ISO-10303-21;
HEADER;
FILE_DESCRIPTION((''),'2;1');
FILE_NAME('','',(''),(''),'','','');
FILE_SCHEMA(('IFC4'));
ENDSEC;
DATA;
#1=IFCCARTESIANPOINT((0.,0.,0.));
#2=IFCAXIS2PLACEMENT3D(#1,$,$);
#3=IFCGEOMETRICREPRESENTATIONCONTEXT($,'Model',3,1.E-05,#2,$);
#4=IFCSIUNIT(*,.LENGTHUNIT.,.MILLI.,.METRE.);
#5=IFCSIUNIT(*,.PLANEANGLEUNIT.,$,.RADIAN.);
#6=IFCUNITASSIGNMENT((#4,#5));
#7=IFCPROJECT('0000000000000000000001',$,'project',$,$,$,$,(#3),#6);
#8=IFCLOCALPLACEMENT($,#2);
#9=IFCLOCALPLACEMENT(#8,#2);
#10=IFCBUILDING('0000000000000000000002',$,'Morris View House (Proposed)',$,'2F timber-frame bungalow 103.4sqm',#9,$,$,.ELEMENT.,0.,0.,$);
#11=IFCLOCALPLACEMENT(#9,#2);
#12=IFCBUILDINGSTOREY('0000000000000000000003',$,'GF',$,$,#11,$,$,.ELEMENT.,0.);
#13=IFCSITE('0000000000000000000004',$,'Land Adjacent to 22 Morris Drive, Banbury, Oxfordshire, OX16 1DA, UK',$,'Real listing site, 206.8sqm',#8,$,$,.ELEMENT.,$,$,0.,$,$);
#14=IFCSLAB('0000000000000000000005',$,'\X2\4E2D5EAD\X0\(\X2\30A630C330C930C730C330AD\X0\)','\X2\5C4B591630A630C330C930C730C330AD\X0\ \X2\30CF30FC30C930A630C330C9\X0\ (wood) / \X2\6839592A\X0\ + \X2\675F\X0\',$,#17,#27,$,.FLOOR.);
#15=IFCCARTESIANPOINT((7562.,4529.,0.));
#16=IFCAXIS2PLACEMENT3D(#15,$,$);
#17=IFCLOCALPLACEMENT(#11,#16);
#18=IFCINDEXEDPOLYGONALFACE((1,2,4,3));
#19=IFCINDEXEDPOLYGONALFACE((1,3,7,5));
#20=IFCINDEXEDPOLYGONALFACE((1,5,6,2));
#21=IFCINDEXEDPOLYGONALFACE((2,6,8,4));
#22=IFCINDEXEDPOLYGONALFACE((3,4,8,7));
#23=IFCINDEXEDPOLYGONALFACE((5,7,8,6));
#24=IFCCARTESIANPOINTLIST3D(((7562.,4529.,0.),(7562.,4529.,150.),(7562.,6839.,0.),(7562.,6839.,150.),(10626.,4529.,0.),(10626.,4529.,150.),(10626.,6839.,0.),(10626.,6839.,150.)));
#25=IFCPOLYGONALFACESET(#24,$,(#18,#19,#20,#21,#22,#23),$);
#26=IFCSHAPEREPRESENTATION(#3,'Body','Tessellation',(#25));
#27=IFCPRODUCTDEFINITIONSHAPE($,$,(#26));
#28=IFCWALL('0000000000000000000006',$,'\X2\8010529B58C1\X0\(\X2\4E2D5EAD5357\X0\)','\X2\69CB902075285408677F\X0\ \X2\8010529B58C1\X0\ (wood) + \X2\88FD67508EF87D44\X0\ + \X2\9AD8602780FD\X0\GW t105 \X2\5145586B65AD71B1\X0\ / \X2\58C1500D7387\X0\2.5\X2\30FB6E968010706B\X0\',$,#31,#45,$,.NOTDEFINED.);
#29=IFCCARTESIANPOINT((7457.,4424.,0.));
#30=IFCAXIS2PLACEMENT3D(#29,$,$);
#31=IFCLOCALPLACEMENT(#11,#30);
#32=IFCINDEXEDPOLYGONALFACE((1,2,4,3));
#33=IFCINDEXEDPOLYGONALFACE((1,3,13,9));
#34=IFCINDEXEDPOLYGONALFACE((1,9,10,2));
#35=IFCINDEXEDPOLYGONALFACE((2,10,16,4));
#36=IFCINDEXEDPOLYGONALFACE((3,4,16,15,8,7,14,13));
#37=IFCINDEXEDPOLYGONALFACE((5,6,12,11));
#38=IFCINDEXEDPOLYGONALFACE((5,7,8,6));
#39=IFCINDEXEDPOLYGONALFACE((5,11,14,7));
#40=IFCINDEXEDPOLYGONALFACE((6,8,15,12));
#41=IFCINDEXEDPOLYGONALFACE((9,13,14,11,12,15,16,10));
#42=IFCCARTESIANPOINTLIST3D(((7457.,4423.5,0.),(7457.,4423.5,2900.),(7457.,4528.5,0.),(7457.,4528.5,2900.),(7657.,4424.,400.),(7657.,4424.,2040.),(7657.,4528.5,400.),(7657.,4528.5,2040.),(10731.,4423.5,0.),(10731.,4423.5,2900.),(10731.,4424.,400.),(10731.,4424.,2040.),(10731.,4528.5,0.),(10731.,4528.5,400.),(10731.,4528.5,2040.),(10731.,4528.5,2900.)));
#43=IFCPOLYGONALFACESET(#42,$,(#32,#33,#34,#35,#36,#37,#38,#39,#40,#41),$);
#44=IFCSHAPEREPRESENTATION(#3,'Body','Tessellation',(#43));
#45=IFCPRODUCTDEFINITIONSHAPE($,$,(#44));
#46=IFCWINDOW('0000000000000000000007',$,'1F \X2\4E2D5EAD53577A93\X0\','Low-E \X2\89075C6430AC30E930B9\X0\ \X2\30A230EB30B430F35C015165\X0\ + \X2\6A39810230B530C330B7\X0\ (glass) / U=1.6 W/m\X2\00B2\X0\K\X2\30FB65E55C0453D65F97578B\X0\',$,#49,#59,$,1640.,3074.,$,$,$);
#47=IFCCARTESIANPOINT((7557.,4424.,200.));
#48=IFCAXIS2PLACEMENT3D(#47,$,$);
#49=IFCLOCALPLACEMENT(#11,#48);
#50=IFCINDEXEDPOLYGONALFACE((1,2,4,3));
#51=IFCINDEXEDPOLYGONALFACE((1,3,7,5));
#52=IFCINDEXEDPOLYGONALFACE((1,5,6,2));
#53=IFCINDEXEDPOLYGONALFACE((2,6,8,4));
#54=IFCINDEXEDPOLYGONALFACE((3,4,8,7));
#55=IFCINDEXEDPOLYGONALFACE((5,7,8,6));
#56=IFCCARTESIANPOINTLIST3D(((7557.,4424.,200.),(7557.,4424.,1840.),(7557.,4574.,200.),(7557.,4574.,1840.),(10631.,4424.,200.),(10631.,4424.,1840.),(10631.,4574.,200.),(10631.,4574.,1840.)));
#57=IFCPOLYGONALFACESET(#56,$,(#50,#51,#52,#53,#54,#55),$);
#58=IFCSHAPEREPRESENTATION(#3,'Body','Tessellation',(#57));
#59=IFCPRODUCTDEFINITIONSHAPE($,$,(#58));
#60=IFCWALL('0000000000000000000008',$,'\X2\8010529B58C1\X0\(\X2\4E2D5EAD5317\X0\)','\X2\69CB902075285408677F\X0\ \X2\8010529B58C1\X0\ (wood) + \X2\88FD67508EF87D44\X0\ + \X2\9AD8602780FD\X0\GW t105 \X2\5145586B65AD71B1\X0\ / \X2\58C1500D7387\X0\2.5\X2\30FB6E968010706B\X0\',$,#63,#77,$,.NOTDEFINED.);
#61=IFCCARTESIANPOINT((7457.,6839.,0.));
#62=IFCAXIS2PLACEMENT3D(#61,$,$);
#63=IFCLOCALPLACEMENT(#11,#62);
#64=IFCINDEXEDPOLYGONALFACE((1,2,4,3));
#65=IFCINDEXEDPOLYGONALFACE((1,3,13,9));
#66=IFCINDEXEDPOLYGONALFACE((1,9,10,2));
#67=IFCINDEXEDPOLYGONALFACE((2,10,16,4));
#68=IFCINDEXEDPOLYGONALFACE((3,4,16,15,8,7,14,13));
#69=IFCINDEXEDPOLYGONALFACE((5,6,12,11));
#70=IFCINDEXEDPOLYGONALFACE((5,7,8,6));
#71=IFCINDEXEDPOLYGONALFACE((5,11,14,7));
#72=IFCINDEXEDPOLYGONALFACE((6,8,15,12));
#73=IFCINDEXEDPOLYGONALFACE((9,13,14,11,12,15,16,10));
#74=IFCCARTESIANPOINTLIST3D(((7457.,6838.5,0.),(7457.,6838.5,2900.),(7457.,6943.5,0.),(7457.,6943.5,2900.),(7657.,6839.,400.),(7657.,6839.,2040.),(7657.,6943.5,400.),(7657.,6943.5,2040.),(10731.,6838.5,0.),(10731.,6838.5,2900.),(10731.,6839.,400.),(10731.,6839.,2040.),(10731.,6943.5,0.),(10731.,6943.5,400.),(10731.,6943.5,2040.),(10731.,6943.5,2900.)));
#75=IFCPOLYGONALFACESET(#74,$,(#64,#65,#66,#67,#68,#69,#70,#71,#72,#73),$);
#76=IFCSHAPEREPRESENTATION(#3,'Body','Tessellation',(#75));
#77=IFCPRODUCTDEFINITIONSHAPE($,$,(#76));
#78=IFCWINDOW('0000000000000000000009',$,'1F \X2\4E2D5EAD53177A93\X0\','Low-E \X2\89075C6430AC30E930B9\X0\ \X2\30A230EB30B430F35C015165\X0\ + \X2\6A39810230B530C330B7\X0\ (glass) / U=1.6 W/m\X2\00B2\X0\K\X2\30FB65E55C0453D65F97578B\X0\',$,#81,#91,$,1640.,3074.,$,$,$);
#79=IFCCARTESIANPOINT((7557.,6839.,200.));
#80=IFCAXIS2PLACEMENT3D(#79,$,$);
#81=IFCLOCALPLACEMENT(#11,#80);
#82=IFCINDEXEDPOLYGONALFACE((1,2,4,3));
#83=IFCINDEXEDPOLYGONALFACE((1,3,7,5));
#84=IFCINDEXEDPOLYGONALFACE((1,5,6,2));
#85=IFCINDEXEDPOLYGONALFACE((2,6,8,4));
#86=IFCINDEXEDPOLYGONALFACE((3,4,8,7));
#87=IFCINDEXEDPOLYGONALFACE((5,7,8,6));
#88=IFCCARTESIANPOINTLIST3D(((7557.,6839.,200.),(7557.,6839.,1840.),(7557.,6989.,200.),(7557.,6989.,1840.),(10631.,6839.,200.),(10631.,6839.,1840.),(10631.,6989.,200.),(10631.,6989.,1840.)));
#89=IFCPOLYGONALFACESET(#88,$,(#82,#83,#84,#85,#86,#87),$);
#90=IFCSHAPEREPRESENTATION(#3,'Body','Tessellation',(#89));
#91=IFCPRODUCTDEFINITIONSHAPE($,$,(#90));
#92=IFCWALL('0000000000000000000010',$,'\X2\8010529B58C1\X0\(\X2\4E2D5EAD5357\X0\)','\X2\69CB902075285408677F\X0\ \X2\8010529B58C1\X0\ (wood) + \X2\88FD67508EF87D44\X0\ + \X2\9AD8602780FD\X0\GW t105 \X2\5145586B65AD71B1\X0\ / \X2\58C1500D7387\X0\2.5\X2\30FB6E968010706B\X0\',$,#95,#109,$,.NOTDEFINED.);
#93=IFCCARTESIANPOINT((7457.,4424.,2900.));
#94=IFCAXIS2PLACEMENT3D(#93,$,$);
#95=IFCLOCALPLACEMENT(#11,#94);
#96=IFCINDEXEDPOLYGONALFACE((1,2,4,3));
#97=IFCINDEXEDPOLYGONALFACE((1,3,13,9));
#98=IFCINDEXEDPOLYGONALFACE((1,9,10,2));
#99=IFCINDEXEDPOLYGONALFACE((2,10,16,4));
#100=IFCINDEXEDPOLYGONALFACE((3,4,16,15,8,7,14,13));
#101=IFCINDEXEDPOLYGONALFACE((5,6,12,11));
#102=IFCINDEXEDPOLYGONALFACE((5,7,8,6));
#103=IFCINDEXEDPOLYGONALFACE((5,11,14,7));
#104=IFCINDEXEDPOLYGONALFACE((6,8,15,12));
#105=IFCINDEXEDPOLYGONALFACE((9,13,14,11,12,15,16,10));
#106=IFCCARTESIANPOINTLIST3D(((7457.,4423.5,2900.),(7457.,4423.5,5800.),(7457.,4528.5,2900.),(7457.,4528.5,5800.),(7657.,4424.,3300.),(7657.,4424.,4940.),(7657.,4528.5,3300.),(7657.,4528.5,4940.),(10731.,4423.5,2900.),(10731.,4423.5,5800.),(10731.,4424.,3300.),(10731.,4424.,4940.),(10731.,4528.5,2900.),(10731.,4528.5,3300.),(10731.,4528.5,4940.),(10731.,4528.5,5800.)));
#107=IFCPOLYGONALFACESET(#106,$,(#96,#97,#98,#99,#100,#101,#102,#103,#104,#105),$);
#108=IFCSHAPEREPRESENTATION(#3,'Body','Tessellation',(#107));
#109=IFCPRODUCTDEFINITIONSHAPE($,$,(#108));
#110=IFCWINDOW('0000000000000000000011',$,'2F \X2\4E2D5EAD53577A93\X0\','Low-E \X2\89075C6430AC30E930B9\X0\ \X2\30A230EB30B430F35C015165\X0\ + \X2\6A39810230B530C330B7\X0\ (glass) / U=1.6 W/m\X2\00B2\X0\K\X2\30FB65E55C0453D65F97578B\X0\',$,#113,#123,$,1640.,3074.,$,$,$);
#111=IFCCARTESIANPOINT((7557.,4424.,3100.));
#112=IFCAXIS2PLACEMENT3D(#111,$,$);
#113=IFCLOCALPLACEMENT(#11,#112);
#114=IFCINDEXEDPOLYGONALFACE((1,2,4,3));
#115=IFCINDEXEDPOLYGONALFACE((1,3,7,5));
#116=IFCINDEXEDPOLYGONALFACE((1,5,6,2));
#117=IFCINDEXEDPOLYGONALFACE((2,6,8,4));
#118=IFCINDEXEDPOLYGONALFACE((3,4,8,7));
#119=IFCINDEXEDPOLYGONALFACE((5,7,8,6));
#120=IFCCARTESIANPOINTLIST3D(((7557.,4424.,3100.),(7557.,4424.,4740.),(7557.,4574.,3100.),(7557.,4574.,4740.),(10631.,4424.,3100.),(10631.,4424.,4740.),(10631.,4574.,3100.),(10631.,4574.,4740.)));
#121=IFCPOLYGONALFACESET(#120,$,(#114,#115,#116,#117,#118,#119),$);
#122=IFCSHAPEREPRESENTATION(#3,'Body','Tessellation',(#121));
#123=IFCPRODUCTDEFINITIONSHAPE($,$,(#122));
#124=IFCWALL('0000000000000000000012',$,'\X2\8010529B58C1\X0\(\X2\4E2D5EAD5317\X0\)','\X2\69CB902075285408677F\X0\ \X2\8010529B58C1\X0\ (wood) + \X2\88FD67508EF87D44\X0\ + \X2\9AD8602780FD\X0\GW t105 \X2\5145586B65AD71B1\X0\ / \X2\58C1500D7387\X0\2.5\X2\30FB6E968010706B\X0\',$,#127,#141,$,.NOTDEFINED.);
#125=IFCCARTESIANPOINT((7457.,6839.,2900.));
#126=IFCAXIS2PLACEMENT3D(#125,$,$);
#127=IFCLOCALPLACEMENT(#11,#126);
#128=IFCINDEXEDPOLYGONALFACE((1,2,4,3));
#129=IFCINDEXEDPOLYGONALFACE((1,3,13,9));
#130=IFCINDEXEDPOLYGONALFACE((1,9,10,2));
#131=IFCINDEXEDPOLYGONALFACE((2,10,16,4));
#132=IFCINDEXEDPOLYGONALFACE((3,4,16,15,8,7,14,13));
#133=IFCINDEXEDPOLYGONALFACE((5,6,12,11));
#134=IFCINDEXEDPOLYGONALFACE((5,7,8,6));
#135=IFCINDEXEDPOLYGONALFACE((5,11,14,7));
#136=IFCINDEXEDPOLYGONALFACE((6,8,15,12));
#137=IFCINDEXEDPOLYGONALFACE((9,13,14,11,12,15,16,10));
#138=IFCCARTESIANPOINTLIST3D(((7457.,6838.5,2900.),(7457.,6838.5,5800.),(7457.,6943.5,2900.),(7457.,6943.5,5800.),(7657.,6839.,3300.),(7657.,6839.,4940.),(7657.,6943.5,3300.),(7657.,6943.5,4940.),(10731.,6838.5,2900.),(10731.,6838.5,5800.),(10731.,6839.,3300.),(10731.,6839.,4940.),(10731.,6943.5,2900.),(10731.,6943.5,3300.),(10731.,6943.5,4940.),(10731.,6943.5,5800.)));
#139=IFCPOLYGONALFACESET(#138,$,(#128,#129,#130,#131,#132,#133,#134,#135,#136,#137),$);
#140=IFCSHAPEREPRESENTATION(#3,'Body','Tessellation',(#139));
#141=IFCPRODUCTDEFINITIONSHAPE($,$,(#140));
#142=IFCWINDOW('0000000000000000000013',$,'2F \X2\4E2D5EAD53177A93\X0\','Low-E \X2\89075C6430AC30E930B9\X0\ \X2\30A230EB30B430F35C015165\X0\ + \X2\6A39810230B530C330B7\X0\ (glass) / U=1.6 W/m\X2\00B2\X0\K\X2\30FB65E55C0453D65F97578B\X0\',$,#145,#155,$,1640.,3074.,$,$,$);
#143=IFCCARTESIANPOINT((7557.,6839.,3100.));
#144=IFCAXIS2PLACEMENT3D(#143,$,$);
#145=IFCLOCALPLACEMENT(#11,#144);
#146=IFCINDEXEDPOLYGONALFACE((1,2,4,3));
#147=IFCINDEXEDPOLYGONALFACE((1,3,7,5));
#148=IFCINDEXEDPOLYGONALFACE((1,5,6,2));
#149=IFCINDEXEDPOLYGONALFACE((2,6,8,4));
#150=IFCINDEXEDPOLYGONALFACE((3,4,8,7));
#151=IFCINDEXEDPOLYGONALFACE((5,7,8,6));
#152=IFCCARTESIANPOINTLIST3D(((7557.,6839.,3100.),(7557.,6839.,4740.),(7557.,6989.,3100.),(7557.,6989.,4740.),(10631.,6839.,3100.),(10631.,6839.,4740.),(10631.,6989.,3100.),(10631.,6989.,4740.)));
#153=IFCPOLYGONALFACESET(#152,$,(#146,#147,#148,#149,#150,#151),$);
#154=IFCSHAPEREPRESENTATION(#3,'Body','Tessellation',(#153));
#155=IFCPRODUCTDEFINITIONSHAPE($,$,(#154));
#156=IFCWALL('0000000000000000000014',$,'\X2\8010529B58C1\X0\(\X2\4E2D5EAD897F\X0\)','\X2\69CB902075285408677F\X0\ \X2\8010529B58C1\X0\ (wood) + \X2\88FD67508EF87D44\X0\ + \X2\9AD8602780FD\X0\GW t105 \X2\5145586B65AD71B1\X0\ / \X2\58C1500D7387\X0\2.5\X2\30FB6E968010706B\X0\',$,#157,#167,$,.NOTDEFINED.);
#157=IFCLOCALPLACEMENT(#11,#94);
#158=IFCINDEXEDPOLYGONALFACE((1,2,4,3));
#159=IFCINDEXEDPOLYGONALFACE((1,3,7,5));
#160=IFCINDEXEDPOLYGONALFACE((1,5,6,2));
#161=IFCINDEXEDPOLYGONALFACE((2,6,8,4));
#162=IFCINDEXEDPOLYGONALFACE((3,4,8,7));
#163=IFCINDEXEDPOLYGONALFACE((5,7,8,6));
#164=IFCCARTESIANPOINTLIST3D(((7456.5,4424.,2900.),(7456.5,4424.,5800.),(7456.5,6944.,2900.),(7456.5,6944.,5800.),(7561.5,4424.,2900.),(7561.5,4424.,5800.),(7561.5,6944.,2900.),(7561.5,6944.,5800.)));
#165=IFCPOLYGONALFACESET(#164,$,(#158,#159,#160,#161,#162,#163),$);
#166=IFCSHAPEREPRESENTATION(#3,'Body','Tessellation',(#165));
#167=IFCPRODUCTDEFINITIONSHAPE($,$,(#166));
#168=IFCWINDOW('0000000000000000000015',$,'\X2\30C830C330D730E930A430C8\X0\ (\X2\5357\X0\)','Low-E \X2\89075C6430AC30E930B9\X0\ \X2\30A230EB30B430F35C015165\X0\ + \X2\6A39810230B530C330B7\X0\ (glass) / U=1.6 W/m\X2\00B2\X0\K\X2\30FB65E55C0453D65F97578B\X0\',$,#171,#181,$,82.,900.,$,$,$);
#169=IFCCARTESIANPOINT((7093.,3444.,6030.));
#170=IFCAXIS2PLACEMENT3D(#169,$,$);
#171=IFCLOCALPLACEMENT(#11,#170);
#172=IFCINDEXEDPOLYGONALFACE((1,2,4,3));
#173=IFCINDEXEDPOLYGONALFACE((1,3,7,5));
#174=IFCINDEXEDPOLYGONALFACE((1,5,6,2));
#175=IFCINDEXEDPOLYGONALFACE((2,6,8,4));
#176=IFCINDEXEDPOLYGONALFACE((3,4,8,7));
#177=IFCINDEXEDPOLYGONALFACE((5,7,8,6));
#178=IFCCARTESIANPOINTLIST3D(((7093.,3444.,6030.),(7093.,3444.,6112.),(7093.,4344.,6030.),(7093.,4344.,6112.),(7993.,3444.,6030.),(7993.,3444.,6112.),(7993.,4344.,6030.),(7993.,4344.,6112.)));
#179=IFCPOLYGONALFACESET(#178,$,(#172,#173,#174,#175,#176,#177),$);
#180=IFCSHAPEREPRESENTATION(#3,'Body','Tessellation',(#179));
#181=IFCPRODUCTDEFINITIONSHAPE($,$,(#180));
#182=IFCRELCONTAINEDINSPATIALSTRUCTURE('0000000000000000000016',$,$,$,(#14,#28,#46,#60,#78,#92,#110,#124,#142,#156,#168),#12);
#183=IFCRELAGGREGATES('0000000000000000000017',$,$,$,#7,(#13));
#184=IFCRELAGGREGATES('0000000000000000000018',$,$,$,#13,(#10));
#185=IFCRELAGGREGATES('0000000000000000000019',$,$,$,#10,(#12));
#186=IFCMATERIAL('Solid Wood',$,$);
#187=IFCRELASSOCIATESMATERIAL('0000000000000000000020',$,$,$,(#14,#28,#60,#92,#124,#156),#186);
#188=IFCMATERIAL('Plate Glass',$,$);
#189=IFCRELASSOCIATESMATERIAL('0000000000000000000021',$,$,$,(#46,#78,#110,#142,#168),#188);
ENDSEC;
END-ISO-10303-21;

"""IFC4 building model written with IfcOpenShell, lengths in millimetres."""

from ifc_helpers import new_model, si_unit, frame, frame_2d, origin, place, context, project, spatial, rectangle, extrude, material, element, fill, save


model = new_model("IFC4")

# Units and contexts
model_context = context("Model", 3, precision=1e-05, world=origin())
ifc_project = project(units=[si_unit("LENGTHUNIT", "METRE", prefix="MILLI"), si_unit("PLANEANGLEUNIT", "RADIAN")], contexts=[model_context])

# Site, building, storey
site_placement = place(None, origin())
site = spatial("IfcSite", under=ifc_project, at=site_placement, Name="Land Adjacent to 22 Morris Drive, Banbury, Oxfordshire, OX16 1DA, UK", ObjectType="Real listing site, 206.8sqm", CompositionType="ELEMENT", RefElevation=0.0)
building_placement = place(site_placement, origin())
building = spatial("IfcBuilding", under=site, at=building_placement, Name="Morris View House (Proposed)", ObjectType="2F timber-frame bungalow 103.4sqm", CompositionType="ELEMENT", ElevationOfRefHeight=0.0, ElevationOfTerrain=0.0)
storey_placement = place(building_placement, origin())
storey = spatial("IfcBuildingStorey", under=building, at=storey_placement, Name="GF", CompositionType="ELEMENT", Elevation=0.0)

# Slab
ifc_material_1 = material(Name="Solid Wood")
slab_placement = place(storey_placement, frame((7562.0, 4529.0, 0.0)))
element("IfcSlab", 1, at=slab_placement, inside=storey, material=ifc_material_1, Name="中庭(ウッドデッキ)", Description="屋外ウッドデッキ ハードウッド (wood) / 根太 + 束", PredefinedType="FLOOR", context=model_context, shape_type="SweptSolid", body=[
    extrude(rectangle(XDim=3064.0, YDim=2310.0, at=frame_2d((1532.0, 1155.0))), frame((7562.0, 4529.0, 0.0)), (0.0, 0.0, 1.0), 150.0),
])

# Walls, openings, windows
wall_1_placement = place(storey_placement, frame((7457.0, 4424.0, 0.0)))
wall_1 = element("IfcWall", 2, at=wall_1_placement, inside=storey, material=ifc_material_1, Name="耐力壁(中庭南)", Description="構造用合板 耐力壁 (wood) + 製材軸組 + 高性能GW t105 充填断熱 / 壁倍率2.5・準耐火", PredefinedType="NOTDEFINED", context=model_context, shape_type="SweptSolid", body=[
    extrude(rectangle(XDim=3274.0, YDim=105.0, at=frame_2d((1637.0, 52.0))), frame((7457.0, 4424.0, 0.0)), (0.0, 0.0, 1.0), 2900.0),
])
opening_1_placement = place(storey_placement, frame((7557.0, 4424.0, 200.0)))
opening_1 = element("IfcOpeningElement", 3, at=opening_1_placement, cuts=wall_1, PredefinedType="NOTDEFINED", context=model_context, shape_type="SweptSolid", body=[
    extrude(rectangle(XDim=3074.0, YDim=150.0, at=frame_2d((1537.0, 75.0))), frame((7557.0, 4424.0, 200.0)), (0.0, 0.0, 1.0), 1640.0),
])
ifc_material_2 = material(Name="Plate Glass")
window_1_placement = place(storey_placement, frame((7557.0, 4424.0, 200.0)))
window_1 = element("IfcWindow", 4, at=window_1_placement, inside=storey, material=ifc_material_2, Name="1F 中庭南窓", Description="Low-E 複層ガラス アルゴン封入 + 樹脂サッシ (glass) / U=1.6 W/m²K・日射取得型", OverallHeight=1640.0, OverallWidth=3074.0, context=model_context, shape_type="SweptSolid", body=[
    extrude(rectangle(XDim=3074.0, YDim=150.0, at=frame_2d((1537.0, 75.0))), frame((7557.0, 4424.0, 200.0)), (0.0, 0.0, 1.0), 1640.0),
])
fill(opening_1, window_1)
wall_2_placement = place(storey_placement, frame((7457.0, 6839.0, 0.0)))
wall_2 = element("IfcWall", 5, at=wall_2_placement, inside=storey, material=ifc_material_1, Name="耐力壁(中庭北)", Description="構造用合板 耐力壁 (wood) + 製材軸組 + 高性能GW t105 充填断熱 / 壁倍率2.5・準耐火", PredefinedType="NOTDEFINED", context=model_context, shape_type="SweptSolid", body=[
    extrude(rectangle(XDim=3274.0, YDim=105.0, at=frame_2d((1637.0, 52.0))), frame((7457.0, 6839.0, 0.0)), (0.0, 0.0, 1.0), 2900.0),
])
opening_2_placement = place(storey_placement, frame((7557.0, 6839.0, 200.0)))
opening_2 = element("IfcOpeningElement", 6, at=opening_2_placement, cuts=wall_2, PredefinedType="NOTDEFINED", context=model_context, shape_type="SweptSolid", body=[
    extrude(rectangle(XDim=3074.0, YDim=150.0, at=frame_2d((1537.0, 75.0))), frame((7557.0, 6839.0, 200.0)), (0.0, 0.0, 1.0), 1640.0),
])
window_2_placement = place(storey_placement, frame((7557.0, 6839.0, 200.0)))
window_2 = element("IfcWindow", 7, at=window_2_placement, inside=storey, material=ifc_material_2, Name="1F 中庭北窓", Description="Low-E 複層ガラス アルゴン封入 + 樹脂サッシ (glass) / U=1.6 W/m²K・日射取得型", OverallHeight=1640.0, OverallWidth=3074.0, context=model_context, shape_type="SweptSolid", body=[
    extrude(rectangle(XDim=3074.0, YDim=150.0, at=frame_2d((1537.0, 75.0))), frame((7557.0, 6839.0, 200.0)), (0.0, 0.0, 1.0), 1640.0),
])
fill(opening_2, window_2)

# Walls, openings, windows
wall_3_placement = place(storey_placement, frame((7457.0, 4424.0, 2900.0)))
wall_3 = element("IfcWall", 8, at=wall_3_placement, inside=storey, material=ifc_material_1, Name="耐力壁(中庭南)", Description="構造用合板 耐力壁 (wood) + 製材軸組 + 高性能GW t105 充填断熱 / 壁倍率2.5・準耐火", PredefinedType="NOTDEFINED", context=model_context, shape_type="SweptSolid", body=[
    extrude(rectangle(XDim=3274.0, YDim=105.0, at=frame_2d((1637.0, 52.0))), frame((7457.0, 4424.0, 2900.0)), (0.0, 0.0, 1.0), 2900.0),
])
opening_3_placement = place(storey_placement, frame((7557.0, 4424.0, 3100.0)))
opening_3 = element("IfcOpeningElement", 9, at=opening_3_placement, cuts=wall_3, PredefinedType="NOTDEFINED", context=model_context, shape_type="SweptSolid", body=[
    extrude(rectangle(XDim=3074.0, YDim=150.0, at=frame_2d((1537.0, 75.0))), frame((7557.0, 4424.0, 3100.0)), (0.0, 0.0, 1.0), 1640.0),
])
window_3_placement = place(storey_placement, frame((7557.0, 4424.0, 3100.0)))
window_3 = element("IfcWindow", 10, at=window_3_placement, inside=storey, material=ifc_material_2, Name="2F 中庭南窓", Description="Low-E 複層ガラス アルゴン封入 + 樹脂サッシ (glass) / U=1.6 W/m²K・日射取得型", OverallHeight=1640.0, OverallWidth=3074.0, context=model_context, shape_type="SweptSolid", body=[
    extrude(rectangle(XDim=3074.0, YDim=150.0, at=frame_2d((1537.0, 75.0))), frame((7557.0, 4424.0, 3100.0)), (0.0, 0.0, 1.0), 1640.0),
])
fill(opening_3, window_3)
wall_4_placement = place(storey_placement, frame((7457.0, 6839.0, 2900.0)))
wall_4 = element("IfcWall", 11, at=wall_4_placement, inside=storey, material=ifc_material_1, Name="耐力壁(中庭北)", Description="構造用合板 耐力壁 (wood) + 製材軸組 + 高性能GW t105 充填断熱 / 壁倍率2.5・準耐火", PredefinedType="NOTDEFINED", context=model_context, shape_type="SweptSolid", body=[
    extrude(rectangle(XDim=3274.0, YDim=105.0, at=frame_2d((1637.0, 52.0))), frame((7457.0, 6839.0, 2900.0)), (0.0, 0.0, 1.0), 2900.0),
])
opening_4_placement = place(storey_placement, frame((7557.0, 6839.0, 3100.0)))
opening_4 = element("IfcOpeningElement", 12, at=opening_4_placement, cuts=wall_4, PredefinedType="NOTDEFINED", context=model_context, shape_type="SweptSolid", body=[
    extrude(rectangle(XDim=3074.0, YDim=150.0, at=frame_2d((1537.0, 75.0))), frame((7557.0, 6839.0, 3100.0)), (0.0, 0.0, 1.0), 1640.0),
])
window_4_placement = place(storey_placement, frame((7557.0, 6839.0, 3100.0)))
window_4 = element("IfcWindow", 13, at=window_4_placement, inside=storey, material=ifc_material_2, Name="2F 中庭北窓", Description="Low-E 複層ガラス アルゴン封入 + 樹脂サッシ (glass) / U=1.6 W/m²K・日射取得型", OverallHeight=1640.0, OverallWidth=3074.0, context=model_context, shape_type="SweptSolid", body=[
    extrude(rectangle(XDim=3074.0, YDim=150.0, at=frame_2d((1537.0, 75.0))), frame((7557.0, 6839.0, 3100.0)), (0.0, 0.0, 1.0), 1640.0),
])
fill(opening_4, window_4)

# Wall
wall_5_placement = place(storey_placement, frame((7457.0, 4424.0, 2900.0)))
element("IfcWall", 14, at=wall_5_placement, inside=storey, material=ifc_material_1, Name="耐力壁(中庭西)", Description="構造用合板 耐力壁 (wood) + 製材軸組 + 高性能GW t105 充填断熱 / 壁倍率2.5・準耐火", PredefinedType="NOTDEFINED", context=model_context, shape_type="SweptSolid", body=[
    extrude(rectangle(XDim=105.0, YDim=2520.0, at=frame_2d((52.0, 1260.0))), frame((7457.0, 4424.0, 2900.0)), (0.0, 0.0, 1.0), 2900.0),
])

# Window
window_5_placement = place(storey_placement, frame((7093.0, 3444.0, 6030.0)))
element("IfcWindow", 15, at=window_5_placement, inside=storey, material=ifc_material_2, Name="トップライト (南)", Description="Low-E 複層ガラス アルゴン封入 + 樹脂サッシ (glass) / U=1.6 W/m²K・日射取得型", OverallHeight=82.0, OverallWidth=900.0, context=model_context, shape_type="SweptSolid", body=[
    extrude(rectangle(XDim=900.0, YDim=900.0, at=frame_2d((450.0, 450.0))), frame((7093.0, 3444.0, 6030.0)), (0.0, 0.0, 1.0), 82.0),
])

save(model, "model.ifc")
